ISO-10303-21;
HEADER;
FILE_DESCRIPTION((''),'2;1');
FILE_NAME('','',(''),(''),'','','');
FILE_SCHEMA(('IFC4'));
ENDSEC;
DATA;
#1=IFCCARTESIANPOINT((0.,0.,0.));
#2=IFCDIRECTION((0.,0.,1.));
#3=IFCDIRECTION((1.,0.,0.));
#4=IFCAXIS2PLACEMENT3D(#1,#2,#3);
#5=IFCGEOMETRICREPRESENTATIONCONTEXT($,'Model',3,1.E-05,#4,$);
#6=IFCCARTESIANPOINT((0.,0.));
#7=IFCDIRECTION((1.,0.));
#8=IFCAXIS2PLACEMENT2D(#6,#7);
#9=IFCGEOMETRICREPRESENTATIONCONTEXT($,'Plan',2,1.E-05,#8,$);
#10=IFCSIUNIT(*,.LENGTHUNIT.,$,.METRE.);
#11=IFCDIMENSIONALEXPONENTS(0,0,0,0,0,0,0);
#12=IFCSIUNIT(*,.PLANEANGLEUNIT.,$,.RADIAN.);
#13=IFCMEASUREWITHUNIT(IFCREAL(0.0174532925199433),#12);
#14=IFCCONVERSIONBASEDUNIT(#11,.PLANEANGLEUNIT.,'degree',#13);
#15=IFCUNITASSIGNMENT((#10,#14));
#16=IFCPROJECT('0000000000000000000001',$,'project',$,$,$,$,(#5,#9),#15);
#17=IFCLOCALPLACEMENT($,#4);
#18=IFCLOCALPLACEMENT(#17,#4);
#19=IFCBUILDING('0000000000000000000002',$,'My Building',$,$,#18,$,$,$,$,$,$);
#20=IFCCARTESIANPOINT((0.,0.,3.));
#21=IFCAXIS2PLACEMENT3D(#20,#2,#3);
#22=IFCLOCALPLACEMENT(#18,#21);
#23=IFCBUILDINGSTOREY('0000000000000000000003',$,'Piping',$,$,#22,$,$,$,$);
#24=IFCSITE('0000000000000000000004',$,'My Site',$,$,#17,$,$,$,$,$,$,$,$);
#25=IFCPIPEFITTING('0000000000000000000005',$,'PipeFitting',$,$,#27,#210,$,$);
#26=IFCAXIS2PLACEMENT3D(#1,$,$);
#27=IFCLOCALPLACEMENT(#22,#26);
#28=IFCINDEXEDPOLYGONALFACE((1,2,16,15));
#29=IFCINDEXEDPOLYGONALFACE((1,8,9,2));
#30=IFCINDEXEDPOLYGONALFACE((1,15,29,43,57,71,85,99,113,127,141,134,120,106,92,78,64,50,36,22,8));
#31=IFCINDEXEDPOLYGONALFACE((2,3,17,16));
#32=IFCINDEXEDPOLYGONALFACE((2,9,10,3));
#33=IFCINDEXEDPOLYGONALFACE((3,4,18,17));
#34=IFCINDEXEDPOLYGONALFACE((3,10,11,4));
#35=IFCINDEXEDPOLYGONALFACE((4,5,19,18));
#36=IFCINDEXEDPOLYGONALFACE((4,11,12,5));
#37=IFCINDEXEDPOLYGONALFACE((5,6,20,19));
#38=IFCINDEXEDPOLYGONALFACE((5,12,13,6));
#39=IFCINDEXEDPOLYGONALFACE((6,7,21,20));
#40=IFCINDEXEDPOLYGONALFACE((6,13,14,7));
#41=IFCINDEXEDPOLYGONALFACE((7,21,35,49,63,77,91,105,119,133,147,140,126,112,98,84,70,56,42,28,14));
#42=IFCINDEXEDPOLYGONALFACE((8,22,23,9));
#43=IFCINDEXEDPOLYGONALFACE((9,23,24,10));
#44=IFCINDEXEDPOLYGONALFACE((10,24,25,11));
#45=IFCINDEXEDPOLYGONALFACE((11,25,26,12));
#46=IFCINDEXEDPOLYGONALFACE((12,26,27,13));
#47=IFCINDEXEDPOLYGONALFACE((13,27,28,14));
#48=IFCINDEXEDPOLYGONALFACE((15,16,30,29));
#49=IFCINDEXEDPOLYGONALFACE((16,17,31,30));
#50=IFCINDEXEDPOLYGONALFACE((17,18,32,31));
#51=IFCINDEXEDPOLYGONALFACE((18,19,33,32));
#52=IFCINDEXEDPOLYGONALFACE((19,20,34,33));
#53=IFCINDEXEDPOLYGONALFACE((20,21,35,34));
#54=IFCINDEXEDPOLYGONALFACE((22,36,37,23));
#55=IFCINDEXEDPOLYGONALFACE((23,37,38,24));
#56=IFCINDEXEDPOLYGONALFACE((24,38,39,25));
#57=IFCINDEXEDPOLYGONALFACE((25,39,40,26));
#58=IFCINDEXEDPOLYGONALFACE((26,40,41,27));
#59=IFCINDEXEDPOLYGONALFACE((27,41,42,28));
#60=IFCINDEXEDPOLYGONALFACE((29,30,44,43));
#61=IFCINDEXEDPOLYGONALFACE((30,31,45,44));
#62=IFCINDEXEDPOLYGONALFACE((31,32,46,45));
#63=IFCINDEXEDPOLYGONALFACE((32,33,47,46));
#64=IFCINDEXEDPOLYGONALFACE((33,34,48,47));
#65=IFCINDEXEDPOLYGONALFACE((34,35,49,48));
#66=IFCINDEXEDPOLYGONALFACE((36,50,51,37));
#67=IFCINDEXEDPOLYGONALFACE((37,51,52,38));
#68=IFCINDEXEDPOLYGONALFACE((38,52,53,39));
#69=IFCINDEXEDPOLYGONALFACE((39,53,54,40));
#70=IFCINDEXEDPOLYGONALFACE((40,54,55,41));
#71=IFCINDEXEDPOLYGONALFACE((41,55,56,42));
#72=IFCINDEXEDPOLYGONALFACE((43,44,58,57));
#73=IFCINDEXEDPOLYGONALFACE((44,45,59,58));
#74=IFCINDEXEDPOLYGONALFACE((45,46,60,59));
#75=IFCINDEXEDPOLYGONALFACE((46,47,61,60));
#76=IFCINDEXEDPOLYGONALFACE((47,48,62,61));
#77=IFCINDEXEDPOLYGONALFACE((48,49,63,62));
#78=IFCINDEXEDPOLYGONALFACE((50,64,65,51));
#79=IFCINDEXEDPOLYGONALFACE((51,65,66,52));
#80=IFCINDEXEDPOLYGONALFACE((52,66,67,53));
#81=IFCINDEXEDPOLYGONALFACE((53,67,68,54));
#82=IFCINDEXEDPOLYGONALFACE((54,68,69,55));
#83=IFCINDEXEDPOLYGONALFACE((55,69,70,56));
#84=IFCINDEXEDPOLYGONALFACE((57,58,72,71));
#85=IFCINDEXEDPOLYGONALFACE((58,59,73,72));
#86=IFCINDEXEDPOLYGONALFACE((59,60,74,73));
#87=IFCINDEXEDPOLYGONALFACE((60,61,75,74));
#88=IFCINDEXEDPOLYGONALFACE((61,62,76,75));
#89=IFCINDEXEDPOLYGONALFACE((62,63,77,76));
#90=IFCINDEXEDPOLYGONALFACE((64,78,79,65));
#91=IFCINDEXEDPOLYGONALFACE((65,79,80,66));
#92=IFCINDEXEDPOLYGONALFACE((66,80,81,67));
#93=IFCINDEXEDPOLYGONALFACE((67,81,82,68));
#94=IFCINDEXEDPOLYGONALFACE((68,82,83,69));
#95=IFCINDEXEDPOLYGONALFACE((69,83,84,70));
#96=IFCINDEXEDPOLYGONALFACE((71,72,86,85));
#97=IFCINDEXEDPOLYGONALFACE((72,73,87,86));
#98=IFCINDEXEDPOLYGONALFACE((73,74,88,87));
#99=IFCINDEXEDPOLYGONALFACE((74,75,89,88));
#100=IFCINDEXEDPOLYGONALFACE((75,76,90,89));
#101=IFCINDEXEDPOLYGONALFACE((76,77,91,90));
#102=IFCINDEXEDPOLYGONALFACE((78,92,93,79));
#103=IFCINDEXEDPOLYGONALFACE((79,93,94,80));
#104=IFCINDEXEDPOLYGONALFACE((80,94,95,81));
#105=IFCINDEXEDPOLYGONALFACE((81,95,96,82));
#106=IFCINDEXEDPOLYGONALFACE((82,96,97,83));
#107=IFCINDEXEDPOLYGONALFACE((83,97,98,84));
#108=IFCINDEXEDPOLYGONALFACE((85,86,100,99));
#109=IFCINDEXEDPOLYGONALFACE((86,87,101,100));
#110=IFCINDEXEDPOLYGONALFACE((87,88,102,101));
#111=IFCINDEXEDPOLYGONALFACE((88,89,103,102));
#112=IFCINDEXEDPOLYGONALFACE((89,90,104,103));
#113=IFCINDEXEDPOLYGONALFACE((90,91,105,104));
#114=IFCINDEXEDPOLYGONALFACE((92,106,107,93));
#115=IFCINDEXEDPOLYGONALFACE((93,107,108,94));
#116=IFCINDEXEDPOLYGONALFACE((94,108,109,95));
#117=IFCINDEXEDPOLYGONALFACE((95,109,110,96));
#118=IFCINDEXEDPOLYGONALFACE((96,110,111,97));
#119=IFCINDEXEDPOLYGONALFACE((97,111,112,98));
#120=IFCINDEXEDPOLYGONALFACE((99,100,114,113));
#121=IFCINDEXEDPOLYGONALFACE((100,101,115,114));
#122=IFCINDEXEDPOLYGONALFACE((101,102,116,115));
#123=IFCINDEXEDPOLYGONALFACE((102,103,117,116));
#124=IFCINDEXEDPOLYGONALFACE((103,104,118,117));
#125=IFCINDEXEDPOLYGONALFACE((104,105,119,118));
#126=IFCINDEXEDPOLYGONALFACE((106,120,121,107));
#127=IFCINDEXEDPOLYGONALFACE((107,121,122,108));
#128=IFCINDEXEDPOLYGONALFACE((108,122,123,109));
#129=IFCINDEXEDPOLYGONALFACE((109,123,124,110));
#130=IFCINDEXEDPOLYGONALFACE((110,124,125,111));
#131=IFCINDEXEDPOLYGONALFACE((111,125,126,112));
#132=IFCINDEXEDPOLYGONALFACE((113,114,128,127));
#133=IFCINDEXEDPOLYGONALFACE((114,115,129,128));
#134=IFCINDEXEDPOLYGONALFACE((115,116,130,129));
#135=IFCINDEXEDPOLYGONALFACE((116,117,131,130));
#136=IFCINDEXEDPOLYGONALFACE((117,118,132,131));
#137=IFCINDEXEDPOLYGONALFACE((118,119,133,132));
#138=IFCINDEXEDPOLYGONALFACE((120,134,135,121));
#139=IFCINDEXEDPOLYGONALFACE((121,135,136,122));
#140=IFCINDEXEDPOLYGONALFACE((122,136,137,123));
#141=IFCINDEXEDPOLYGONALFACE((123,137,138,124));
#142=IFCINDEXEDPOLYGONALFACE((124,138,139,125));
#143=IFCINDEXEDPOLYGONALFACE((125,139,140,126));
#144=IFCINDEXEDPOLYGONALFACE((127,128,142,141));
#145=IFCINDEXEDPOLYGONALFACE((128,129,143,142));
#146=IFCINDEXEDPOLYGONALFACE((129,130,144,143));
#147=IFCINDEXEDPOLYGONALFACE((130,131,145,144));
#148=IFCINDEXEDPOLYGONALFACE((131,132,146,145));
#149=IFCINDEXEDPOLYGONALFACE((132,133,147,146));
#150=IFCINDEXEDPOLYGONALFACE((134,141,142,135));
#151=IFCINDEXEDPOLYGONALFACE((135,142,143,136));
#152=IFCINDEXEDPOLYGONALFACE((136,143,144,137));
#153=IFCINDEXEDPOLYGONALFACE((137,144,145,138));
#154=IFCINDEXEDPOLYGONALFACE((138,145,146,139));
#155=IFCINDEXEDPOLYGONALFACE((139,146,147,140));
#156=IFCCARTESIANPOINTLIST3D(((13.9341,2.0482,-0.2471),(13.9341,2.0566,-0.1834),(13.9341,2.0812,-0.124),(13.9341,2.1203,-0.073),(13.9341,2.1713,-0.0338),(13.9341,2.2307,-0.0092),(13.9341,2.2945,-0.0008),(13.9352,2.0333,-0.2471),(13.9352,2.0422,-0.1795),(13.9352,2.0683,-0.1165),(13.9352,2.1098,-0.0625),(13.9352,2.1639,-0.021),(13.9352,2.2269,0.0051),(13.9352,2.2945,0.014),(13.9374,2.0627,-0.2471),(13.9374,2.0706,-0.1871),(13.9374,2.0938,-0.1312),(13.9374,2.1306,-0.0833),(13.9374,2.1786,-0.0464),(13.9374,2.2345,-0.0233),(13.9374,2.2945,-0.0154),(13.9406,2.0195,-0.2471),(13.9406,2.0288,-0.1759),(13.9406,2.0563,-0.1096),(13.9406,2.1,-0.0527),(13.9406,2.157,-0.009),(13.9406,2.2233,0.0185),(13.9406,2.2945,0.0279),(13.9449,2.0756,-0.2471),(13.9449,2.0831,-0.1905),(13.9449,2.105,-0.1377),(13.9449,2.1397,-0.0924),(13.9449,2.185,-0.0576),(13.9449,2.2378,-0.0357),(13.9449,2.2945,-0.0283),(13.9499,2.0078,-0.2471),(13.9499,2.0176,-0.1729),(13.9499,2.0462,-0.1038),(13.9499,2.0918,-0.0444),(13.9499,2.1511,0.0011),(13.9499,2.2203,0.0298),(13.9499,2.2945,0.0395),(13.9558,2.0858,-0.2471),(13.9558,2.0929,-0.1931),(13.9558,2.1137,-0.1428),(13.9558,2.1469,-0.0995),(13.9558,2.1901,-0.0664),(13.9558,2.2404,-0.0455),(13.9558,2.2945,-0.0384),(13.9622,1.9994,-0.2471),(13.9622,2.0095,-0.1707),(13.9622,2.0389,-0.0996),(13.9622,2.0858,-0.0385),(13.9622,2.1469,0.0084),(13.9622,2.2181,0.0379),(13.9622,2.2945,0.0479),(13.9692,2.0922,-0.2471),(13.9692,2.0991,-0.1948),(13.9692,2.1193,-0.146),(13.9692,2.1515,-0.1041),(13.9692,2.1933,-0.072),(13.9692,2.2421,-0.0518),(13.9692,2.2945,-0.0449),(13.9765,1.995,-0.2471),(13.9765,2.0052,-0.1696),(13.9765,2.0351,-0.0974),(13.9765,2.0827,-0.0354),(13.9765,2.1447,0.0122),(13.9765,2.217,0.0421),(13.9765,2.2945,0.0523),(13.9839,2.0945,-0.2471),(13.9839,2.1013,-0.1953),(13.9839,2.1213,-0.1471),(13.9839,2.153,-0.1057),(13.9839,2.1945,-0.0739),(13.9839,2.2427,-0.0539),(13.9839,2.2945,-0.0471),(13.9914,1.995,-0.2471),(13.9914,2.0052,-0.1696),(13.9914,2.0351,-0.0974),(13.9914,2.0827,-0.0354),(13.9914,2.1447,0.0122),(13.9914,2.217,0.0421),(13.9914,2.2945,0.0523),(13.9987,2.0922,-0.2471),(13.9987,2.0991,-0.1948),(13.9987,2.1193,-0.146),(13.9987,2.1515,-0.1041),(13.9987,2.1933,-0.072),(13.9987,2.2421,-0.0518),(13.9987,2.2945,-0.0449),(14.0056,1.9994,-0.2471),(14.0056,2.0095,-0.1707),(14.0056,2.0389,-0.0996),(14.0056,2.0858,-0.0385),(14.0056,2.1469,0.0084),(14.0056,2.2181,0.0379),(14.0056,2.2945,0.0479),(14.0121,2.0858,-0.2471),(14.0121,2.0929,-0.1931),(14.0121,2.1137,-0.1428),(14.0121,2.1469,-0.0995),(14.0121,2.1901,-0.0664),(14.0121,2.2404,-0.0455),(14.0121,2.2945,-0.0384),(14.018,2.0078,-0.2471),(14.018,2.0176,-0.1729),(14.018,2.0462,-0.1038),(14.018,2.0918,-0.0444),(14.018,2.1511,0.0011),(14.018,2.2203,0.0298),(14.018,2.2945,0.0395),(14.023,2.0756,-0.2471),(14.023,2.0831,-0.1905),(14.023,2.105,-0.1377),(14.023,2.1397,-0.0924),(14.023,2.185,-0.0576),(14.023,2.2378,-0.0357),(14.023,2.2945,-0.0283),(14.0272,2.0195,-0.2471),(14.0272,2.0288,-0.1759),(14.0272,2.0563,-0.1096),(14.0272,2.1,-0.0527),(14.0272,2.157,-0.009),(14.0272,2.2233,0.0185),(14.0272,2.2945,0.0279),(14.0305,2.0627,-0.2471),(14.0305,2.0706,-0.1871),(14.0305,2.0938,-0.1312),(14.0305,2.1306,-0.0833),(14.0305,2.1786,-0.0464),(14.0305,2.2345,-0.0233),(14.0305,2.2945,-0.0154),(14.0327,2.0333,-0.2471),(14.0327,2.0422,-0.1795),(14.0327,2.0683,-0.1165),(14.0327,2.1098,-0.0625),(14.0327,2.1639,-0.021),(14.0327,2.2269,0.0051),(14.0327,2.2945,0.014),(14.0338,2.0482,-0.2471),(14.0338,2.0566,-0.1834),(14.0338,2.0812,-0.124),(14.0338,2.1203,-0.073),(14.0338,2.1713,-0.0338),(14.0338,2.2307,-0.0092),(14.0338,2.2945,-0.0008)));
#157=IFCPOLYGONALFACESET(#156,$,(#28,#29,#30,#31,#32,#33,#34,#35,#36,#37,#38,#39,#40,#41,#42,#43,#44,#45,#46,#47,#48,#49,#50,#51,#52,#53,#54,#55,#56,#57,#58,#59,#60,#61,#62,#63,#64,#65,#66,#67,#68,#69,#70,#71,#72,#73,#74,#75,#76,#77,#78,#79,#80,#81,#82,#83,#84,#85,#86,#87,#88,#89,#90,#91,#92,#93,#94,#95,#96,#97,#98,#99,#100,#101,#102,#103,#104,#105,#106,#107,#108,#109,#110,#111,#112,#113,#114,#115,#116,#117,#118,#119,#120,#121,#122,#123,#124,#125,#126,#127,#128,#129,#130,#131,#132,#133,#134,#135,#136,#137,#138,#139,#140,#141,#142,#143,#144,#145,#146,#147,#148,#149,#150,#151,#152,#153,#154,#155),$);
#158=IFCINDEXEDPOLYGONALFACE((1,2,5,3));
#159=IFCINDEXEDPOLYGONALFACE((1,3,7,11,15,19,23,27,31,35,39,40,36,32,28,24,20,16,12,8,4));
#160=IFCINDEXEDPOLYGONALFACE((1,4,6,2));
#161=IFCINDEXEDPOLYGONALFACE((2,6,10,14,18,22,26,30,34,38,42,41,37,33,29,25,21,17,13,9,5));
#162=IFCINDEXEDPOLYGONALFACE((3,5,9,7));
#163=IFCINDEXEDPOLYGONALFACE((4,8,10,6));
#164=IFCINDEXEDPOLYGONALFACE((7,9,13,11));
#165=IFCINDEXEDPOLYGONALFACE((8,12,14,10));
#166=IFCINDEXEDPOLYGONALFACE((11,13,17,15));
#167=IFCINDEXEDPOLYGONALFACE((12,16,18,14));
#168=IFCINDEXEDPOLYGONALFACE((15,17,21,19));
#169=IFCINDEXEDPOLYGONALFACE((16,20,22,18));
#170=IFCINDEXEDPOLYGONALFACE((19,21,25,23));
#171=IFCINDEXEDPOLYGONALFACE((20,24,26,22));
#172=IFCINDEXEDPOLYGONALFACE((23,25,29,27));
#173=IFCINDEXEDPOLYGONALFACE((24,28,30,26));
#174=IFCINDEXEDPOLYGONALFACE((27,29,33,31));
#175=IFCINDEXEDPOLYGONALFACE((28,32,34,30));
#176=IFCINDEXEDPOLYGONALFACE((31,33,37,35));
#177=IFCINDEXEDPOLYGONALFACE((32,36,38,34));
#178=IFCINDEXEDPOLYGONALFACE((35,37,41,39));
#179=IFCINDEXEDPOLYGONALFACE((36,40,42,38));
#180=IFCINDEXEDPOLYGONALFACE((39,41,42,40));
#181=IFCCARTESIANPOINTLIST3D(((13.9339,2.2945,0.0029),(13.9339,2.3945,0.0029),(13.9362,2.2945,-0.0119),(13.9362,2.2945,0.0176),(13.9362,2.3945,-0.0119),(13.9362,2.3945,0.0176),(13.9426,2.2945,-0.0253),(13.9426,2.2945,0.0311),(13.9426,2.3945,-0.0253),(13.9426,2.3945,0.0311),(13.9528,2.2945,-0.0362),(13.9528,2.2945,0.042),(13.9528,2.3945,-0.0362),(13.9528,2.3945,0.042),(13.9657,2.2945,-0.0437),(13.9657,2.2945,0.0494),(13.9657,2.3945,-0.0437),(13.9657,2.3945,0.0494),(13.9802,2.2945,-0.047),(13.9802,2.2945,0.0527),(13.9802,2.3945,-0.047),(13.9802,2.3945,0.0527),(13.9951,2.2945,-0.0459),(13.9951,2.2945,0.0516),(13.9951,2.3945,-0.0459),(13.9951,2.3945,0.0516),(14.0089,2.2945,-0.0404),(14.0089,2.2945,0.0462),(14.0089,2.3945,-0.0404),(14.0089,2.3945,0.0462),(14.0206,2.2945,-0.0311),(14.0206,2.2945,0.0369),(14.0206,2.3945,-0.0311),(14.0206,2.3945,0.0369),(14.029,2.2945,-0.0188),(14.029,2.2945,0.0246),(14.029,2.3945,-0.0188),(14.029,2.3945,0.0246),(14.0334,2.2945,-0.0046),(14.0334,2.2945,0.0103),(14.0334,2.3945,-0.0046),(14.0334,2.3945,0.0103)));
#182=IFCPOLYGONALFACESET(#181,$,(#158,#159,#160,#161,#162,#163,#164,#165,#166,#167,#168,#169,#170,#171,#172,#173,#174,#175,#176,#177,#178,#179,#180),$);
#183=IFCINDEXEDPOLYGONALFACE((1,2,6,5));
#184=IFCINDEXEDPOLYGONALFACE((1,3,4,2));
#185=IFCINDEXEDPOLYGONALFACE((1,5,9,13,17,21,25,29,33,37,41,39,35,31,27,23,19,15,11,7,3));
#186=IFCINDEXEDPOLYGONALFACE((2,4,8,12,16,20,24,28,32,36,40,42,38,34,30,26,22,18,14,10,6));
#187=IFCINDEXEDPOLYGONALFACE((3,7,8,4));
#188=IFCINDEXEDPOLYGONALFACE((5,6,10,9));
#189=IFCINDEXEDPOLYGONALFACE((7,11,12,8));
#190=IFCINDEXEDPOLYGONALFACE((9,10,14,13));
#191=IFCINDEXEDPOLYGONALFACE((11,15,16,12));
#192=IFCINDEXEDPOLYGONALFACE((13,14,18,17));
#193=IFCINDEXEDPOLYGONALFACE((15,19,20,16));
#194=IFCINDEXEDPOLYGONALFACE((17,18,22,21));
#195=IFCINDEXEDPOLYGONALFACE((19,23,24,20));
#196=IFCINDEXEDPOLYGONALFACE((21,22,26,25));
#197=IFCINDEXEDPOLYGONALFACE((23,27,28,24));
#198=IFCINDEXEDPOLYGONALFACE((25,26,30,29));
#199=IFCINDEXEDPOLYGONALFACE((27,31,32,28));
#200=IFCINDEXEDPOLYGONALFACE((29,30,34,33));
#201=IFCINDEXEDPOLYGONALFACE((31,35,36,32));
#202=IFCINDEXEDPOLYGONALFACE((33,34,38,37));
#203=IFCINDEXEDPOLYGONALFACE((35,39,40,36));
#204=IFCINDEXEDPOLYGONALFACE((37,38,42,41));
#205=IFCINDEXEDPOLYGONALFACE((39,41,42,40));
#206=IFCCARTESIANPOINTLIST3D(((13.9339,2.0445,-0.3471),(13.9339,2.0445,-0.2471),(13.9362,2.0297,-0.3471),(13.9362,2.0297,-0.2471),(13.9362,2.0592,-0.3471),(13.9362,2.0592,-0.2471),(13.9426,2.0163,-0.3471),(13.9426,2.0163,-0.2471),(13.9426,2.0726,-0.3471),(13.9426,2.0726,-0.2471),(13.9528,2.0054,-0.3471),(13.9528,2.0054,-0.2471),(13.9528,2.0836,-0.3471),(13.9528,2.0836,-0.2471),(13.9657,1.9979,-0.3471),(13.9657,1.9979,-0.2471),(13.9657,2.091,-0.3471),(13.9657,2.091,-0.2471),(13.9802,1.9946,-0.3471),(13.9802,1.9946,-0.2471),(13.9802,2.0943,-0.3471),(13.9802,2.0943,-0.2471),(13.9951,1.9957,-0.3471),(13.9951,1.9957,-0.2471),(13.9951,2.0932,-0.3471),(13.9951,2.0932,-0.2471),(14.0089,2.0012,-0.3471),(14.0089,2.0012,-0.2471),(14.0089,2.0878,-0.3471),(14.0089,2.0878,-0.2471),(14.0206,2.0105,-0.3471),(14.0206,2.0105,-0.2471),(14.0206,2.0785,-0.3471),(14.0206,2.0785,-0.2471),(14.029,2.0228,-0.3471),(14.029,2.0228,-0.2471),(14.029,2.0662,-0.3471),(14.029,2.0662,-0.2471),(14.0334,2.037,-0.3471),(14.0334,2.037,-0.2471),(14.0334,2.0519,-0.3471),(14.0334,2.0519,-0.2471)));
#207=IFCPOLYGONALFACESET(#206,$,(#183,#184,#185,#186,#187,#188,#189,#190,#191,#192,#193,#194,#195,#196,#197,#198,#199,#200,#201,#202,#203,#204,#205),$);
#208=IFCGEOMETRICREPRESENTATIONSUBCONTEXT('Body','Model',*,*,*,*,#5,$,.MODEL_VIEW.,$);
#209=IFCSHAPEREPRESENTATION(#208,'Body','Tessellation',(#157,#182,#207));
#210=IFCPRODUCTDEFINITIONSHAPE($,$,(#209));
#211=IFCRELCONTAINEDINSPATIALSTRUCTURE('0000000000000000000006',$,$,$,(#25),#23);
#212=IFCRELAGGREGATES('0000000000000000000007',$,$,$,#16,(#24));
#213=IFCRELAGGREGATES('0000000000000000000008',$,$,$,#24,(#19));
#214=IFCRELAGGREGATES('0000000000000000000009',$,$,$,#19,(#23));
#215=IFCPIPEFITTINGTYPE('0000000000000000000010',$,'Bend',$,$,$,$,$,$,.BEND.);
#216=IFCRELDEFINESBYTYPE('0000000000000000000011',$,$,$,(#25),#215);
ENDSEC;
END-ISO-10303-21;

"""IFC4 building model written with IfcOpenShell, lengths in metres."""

from ifc_helpers import new_model, entity, si_unit, converted_unit, frame, origin_with_axes, origin_2d_with_axis, place, context, subcontext, project, spatial, circle, extrude, source, transform, mapped, type_object, type_shapes, element, save


model = new_model("IFC4")

# Units and contexts
model_context = context("Model", 3, precision=1e-05, world=origin_with_axes())
plan_context = context("Plan", 2, precision=1e-05, world=origin_2d_with_axis())
body_context = subcontext(model_context, "Body", "Model", "MODEL_VIEW")
ifc_project = project(units=[si_unit("LENGTHUNIT", "METRE"), converted_unit("PLANEANGLEUNIT", "degree", entity("IfcReal", 0.0174532925199433), si_unit("PLANEANGLEUNIT", "RADIAN"), dimensions=[0, 0, 0, 0, 0, 0, 0])], contexts=[model_context, plan_context])

# Site, building, storey
site_placement = place(None, origin_with_axes())
site = spatial("IfcSite", under=ifc_project, at=site_placement, Name="My Site")
building_placement = place(site_placement, origin_with_axes())
building = spatial("IfcBuilding", under=site, at=building_placement, Name="My Building")
storey_placement = place(building_placement, frame((0.0, 0.0, 3.0), z_axis=(0.0, 0.0, 1.0), x_axis=(1.0, 0.0, 0.0)))
storey = spatial("IfcBuildingStorey", under=building, at=storey_placement, Name="Piping")

# Pipe fitting
pipe_fitting_type_1 = type_object("IfcPipeFittingType", Name="Bend", PredefinedType="BEND")
shared_shape = source(origin_with_axes(), body_context, "Body", "SolidModel", [
    entity("IfcSweptDiskSolid", entity("IfcIndexedPolyCurve", entity("IfcCartesianPointList3D", [[0.0, 0.0, -0.1], [0.0, -0.0732, -0.2768], [0.0, -0.25, -0.35]]), [entity("IfcArcIndex", [1, 2, 3])]), 0.05),
    extrude(circle(Radius=0.05), origin_with_axes(), (0.0, 0.0, -1.0), 0.1),
    extrude(circle(Radius=0.05), frame((0.0, -0.25, -0.35), z_axis=(0.0, -1.0, 0.0), x_axis=(1.0, 0.0, 0.0)), (0.0, 0.0, 1.0), 0.1),
])
type_shapes(pipe_fitting_type_1, [shared_shape])
for number, where, z_axis, x_axis, name in (
    (1, (13.9839, 2.3945, 0.0029), (0.0, 1.0, 0.0), (-1.0, 0.0, 0.0), "PipeFitting"),
):
    element("IfcPipeFitting", number, at=place(storey_placement, frame(where, z_axis=z_axis, x_axis=x_axis)), inside=storey, type_object=pipe_fitting_type_1, Name=name, context=body_context, shape_type="MappedRepresentation", body=[
        mapped(shared_shape, transform((0.0, 0.0, 0.0), x_axis=(1.0, 0.0, 0.0), y_axis=(0.0, 1.0, 0.0), z_axis=(0.0, 0.0, 1.0), scale=1.0)),
    ])

save(model, "model.ifc")
